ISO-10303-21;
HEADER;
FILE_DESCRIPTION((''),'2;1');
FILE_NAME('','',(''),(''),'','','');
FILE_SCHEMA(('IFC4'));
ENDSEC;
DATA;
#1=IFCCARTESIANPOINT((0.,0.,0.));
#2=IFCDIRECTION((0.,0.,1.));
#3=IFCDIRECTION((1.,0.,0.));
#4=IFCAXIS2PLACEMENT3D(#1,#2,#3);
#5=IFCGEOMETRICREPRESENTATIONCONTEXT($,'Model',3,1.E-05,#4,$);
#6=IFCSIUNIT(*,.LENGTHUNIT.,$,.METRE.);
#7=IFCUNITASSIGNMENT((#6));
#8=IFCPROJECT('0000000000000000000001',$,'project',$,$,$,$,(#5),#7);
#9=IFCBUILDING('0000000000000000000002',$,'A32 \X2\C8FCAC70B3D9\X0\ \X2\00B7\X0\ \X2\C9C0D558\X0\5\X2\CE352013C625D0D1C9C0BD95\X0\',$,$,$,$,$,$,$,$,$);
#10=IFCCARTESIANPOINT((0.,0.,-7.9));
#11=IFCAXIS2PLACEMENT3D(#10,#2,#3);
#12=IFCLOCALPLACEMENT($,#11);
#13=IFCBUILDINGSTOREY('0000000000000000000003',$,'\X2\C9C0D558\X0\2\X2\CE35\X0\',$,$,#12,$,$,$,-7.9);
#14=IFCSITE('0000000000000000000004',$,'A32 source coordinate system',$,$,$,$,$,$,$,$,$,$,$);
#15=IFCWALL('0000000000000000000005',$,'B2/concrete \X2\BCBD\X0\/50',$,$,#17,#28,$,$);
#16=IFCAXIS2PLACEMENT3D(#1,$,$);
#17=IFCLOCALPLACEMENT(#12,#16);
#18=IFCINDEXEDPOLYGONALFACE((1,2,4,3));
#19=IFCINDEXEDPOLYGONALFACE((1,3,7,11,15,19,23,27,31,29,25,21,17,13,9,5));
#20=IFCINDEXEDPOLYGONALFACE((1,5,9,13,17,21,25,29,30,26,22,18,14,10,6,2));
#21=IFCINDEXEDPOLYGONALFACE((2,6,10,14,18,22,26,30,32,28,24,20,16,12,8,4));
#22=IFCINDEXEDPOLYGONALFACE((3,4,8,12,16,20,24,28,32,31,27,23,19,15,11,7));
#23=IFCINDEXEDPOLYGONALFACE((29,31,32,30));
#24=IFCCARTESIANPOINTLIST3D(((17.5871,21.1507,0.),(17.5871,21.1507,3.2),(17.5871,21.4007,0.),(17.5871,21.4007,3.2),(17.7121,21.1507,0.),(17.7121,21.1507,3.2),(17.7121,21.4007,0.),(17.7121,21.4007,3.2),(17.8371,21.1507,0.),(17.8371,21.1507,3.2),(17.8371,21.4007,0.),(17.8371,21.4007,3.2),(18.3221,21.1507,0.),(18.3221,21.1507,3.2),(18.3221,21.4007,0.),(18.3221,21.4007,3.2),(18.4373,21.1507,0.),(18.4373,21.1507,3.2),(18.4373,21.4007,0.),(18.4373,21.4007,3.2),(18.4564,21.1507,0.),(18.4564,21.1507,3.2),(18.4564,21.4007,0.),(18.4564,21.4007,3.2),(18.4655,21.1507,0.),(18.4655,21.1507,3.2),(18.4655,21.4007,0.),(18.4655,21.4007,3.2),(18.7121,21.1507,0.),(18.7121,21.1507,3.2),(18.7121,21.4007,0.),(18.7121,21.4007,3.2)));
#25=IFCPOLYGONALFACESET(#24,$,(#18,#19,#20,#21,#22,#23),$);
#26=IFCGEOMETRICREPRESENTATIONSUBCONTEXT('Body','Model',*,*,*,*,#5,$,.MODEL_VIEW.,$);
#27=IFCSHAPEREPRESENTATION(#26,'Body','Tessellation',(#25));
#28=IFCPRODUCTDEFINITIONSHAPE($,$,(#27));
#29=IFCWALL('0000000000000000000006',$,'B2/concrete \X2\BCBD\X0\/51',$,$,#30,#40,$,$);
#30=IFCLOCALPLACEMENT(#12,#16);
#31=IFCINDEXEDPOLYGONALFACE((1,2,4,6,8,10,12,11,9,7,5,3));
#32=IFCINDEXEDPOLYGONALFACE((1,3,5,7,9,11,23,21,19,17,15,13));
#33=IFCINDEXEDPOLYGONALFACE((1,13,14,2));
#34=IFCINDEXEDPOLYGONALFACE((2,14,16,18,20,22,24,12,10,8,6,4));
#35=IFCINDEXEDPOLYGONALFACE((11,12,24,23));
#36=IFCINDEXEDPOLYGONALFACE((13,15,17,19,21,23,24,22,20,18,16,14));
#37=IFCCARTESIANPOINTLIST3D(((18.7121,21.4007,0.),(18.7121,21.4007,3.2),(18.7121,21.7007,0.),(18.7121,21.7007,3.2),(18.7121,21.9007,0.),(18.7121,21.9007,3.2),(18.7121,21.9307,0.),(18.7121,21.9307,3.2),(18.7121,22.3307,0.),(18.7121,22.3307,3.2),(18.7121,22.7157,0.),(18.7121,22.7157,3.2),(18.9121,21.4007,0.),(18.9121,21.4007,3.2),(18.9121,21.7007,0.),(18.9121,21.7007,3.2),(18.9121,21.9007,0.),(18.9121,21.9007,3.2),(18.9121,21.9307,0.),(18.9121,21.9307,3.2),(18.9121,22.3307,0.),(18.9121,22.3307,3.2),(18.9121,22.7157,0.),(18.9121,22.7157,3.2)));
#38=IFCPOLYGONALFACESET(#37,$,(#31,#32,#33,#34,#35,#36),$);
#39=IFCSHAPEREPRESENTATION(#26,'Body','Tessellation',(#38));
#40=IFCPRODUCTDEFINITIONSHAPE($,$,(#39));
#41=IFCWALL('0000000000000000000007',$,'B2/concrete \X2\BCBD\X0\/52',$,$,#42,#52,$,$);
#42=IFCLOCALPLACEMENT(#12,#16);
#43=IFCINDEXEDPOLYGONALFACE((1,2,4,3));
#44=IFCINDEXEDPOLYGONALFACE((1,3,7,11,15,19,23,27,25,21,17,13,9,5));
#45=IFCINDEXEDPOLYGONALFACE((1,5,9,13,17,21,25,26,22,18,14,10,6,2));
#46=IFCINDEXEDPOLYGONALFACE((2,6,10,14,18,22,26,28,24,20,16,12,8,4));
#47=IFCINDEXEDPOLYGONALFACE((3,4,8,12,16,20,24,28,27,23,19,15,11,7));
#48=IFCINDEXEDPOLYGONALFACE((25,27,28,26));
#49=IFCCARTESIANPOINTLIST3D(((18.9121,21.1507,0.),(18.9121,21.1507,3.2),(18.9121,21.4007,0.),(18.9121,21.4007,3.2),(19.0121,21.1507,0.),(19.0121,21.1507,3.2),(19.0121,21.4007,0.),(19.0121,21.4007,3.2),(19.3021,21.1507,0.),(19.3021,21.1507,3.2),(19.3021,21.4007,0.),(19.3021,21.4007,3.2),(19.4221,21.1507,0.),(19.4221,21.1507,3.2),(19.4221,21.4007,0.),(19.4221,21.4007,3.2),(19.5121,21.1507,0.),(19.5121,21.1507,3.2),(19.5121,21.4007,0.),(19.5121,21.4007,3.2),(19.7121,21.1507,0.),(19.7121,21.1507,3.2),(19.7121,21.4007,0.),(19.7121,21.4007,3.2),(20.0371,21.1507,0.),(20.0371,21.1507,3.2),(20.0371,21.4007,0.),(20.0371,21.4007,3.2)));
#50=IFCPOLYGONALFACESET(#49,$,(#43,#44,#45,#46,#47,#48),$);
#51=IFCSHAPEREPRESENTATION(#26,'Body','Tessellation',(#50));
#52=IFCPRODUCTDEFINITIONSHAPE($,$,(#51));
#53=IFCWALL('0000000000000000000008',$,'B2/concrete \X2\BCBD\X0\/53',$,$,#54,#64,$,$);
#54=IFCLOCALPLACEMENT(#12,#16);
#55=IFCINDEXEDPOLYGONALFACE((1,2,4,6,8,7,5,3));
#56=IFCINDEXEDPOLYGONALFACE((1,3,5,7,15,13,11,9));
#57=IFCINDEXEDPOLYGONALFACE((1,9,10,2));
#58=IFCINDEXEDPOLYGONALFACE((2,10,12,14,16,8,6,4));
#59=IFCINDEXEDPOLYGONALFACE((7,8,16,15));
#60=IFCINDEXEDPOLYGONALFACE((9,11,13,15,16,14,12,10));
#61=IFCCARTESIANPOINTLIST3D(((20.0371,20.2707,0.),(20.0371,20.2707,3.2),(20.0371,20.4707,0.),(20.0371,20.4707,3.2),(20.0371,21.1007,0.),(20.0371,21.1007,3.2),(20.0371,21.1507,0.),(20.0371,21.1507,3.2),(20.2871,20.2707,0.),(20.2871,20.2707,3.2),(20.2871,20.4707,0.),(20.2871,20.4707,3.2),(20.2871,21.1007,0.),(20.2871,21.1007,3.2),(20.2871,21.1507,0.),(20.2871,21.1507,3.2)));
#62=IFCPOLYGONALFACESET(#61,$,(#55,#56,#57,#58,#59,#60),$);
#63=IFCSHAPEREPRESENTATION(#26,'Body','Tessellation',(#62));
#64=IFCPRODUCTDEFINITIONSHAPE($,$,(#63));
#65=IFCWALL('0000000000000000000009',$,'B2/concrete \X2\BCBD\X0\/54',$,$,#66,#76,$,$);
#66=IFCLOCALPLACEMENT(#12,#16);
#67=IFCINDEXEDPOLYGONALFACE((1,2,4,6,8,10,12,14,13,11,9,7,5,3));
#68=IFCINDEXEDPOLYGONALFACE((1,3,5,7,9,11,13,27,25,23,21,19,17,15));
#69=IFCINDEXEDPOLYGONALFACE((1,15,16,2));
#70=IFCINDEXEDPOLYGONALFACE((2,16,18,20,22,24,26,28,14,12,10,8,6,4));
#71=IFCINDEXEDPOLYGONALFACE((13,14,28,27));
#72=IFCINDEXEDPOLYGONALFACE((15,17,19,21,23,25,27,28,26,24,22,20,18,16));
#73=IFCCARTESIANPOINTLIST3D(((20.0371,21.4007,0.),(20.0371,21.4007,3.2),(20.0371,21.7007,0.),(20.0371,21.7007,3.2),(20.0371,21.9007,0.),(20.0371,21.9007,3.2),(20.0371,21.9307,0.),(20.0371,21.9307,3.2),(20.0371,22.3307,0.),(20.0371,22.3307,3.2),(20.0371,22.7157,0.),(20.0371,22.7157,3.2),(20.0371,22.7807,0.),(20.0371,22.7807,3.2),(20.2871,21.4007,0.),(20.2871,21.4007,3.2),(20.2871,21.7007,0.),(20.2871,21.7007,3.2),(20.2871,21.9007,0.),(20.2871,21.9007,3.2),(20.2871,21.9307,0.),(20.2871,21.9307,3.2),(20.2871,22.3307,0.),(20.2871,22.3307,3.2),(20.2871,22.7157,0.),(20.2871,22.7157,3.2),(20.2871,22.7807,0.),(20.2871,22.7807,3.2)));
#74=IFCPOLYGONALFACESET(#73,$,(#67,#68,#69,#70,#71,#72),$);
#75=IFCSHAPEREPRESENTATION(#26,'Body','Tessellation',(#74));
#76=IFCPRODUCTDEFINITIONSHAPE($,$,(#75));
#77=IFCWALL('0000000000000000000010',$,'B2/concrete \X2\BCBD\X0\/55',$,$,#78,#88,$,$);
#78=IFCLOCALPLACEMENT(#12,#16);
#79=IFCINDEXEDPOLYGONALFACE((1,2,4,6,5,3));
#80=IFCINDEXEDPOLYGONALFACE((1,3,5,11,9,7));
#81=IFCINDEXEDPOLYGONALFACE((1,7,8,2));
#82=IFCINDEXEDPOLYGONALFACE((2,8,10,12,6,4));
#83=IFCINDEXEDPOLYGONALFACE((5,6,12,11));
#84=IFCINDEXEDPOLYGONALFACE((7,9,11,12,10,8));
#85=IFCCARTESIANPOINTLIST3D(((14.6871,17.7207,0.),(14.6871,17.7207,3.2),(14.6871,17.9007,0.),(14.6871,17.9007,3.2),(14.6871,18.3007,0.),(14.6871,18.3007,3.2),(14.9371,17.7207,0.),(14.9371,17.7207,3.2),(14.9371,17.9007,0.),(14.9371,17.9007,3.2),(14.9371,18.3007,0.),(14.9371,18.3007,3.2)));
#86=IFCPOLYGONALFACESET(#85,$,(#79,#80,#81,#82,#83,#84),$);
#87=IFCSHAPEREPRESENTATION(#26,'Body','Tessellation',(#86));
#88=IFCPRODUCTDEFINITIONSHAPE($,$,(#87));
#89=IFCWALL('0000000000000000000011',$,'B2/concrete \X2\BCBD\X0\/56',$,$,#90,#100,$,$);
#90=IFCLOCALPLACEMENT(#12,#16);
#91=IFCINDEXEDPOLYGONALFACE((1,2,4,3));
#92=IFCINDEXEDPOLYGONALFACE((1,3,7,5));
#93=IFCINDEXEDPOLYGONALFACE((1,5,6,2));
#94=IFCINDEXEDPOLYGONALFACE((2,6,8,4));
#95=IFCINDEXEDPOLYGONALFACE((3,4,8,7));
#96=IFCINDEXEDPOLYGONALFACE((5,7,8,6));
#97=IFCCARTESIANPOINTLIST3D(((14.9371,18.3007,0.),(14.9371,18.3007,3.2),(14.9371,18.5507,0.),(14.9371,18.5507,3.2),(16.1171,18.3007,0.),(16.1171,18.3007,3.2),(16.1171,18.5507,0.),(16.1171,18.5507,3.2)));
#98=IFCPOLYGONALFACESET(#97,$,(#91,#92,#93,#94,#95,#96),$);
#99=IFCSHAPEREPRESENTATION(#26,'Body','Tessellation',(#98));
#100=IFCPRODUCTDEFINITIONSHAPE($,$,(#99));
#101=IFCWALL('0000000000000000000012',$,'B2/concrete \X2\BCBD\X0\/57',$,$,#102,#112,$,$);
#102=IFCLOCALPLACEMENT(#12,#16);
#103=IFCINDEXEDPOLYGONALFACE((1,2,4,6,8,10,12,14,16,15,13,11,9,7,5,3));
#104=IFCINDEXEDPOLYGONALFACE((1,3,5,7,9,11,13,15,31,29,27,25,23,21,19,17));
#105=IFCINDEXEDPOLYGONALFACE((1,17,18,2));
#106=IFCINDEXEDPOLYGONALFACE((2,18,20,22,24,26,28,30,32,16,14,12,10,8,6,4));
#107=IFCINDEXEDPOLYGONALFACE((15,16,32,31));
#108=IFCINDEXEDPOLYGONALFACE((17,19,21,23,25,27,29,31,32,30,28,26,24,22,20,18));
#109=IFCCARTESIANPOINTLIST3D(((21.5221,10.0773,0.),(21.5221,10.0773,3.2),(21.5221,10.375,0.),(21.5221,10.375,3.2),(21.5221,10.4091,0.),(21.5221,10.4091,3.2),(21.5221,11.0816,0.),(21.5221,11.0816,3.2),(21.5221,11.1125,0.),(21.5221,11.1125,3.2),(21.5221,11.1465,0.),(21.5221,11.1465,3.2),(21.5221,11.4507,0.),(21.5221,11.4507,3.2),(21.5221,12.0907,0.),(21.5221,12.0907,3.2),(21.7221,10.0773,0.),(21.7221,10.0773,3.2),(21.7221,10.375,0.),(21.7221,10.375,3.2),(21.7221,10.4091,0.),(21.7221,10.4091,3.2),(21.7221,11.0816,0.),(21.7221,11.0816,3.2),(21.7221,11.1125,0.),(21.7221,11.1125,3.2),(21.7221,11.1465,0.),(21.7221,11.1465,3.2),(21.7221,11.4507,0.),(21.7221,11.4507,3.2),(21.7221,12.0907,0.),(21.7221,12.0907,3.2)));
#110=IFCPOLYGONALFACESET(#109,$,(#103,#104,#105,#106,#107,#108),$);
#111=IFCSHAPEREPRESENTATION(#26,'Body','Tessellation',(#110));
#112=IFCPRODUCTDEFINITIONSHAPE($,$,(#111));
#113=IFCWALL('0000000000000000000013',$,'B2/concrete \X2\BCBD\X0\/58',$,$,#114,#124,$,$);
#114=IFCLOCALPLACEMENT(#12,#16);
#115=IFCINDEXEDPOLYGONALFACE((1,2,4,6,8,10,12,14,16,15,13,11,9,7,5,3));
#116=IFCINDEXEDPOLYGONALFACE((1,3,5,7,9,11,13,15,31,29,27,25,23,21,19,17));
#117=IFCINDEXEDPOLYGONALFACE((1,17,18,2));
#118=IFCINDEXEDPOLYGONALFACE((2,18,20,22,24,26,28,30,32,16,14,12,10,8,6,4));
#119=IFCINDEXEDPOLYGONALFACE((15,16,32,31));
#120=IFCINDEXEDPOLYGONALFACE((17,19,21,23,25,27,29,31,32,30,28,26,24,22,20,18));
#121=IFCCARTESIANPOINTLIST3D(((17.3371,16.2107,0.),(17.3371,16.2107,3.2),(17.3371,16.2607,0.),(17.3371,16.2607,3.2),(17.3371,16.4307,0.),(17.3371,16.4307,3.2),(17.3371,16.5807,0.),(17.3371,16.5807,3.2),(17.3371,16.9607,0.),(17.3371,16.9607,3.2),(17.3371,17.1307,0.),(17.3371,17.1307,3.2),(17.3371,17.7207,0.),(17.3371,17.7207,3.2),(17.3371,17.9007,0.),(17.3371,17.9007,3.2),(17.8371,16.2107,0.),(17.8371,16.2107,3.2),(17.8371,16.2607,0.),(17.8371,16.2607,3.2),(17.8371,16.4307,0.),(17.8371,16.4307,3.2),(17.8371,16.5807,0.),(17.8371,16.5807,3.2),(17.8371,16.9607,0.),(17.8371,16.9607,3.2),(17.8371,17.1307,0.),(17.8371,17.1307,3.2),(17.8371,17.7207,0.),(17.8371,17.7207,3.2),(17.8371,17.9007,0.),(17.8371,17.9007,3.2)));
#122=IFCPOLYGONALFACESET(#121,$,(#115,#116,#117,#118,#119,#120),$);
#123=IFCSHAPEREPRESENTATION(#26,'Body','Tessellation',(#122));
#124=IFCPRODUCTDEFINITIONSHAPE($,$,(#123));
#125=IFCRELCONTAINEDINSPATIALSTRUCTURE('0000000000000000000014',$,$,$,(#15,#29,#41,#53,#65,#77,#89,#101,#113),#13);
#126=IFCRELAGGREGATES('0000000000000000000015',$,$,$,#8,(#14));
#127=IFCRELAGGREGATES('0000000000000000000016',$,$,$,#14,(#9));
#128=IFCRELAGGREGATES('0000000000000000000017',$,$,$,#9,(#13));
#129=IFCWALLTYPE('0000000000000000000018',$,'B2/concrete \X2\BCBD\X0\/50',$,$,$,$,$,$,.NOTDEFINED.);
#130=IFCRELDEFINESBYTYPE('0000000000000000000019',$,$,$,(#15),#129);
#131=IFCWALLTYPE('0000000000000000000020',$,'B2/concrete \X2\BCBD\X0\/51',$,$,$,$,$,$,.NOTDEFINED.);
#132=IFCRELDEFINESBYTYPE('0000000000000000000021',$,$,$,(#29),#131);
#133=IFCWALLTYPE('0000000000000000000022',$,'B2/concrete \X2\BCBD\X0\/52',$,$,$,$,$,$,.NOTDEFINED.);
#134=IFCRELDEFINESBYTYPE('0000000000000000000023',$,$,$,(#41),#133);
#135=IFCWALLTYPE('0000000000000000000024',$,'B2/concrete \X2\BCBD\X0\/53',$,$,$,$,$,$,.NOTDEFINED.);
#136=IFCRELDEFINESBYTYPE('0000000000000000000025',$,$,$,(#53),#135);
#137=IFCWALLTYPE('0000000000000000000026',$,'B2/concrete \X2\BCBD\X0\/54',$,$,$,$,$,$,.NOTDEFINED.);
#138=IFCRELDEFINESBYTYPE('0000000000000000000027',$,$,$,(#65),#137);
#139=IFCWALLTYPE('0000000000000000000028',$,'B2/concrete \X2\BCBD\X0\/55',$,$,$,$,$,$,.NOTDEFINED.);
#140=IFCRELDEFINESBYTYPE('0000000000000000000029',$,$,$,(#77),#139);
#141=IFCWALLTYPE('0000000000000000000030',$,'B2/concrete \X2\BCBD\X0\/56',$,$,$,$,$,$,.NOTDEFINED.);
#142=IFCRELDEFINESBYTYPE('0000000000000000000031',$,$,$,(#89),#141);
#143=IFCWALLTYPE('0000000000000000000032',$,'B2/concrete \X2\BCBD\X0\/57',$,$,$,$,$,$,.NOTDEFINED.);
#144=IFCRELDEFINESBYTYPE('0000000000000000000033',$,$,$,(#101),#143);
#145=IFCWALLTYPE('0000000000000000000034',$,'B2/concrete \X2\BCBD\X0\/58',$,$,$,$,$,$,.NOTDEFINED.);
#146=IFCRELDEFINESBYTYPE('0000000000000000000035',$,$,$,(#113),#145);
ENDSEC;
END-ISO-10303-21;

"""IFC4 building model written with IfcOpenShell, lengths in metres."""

from ifc_helpers import new_model, si_unit, frame, origin, origin_with_axes, place, context, subcontext, project, spatial, polyline, outline, extrude, source, transform, mapped, type_object, type_shapes, element, save


model = new_model("IFC4")

# Units and contexts
model_context = context("Model", 3, precision=1e-05, world=origin_with_axes())
body_context = subcontext(model_context, "Body", "Model", "MODEL_VIEW")
ifc_project = project(units=[si_unit("LENGTHUNIT", "METRE")], contexts=[model_context])

# Site, building, storey
site = spatial("IfcSite", under=ifc_project, Name="A32 source coordinate system")
building = spatial("IfcBuilding", under=site, Name="A32 주거동 · 지하5층–옥탑지붕")
storey_placement = place(None, frame((0.0, 0.0, -7.9), z_axis=(0.0, 0.0, 1.0), x_axis=(1.0, 0.0, 0.0)))
storey = spatial("IfcBuildingStorey", under=building, at=storey_placement, Name="지하2층", Elevation=-7.9)

# Walls
wall_type_1 = type_object("IfcWallType", Name="B2/concrete 벽/50", PredefinedType="NOTDEFINED")
shared_shape_1 = source(origin(), body_context, "Body", "SweptSolid", [
    extrude(outline(polyline([(17.8371, 21.4007), (18.3221, 21.4007), (18.4373, 21.4007), (18.4564, 21.4007), (18.4655, 21.4007), (18.7121, 21.4007), (18.7121, 21.1507), (18.4655, 21.1507), (18.4564, 21.1507), (18.4373, 21.1507), (18.3221, 21.1507), (17.8371, 21.1507), (17.7121, 21.1507), (17.5871, 21.1507), (17.5871, 21.4007), (17.7121, 21.4007), (17.8371, 21.4007)])), origin(), (0.0, 0.0, 1.0), 3.2),
])
type_shapes(wall_type_1, [shared_shape_1])
wall_1_placement = place(storey_placement, origin_with_axes())
element("IfcWall", 1, at=wall_1_placement, inside=storey, type_object=wall_type_1, Name="B2/concrete 벽/50", context=body_context, shape_type="MappedRepresentation", body=[
    mapped(shared_shape_1, transform((0.0, 0.0, 0.0), scale=1.0)),
])
wall_type_2 = type_object("IfcWallType", Name="B2/concrete 벽/51", PredefinedType="NOTDEFINED")
shared_shape_2 = source(origin(), body_context, "Body", "SweptSolid", [
    extrude(outline(polyline([(18.7121, 21.9307), (18.7121, 22.3307), (18.7121, 22.7157), (18.9121, 22.7157), (18.9121, 22.3307), (18.9121, 21.9307), (18.9121, 21.9007), (18.9121, 21.7007), (18.9121, 21.4007), (18.7121, 21.4007), (18.7121, 21.7007), (18.7121, 21.9007), (18.7121, 21.9307)])), origin(), (0.0, 0.0, 1.0), 3.2),
])
type_shapes(wall_type_2, [shared_shape_2])
wall_2_placement = place(storey_placement, origin_with_axes())
element("IfcWall", 2, at=wall_2_placement, inside=storey, type_object=wall_type_2, Name="B2/concrete 벽/51", context=body_context, shape_type="MappedRepresentation", body=[
    mapped(shared_shape_2, transform((0.0, 0.0, 0.0), scale=1.0)),
])
wall_type_3 = type_object("IfcWallType", Name="B2/concrete 벽/52", PredefinedType="NOTDEFINED")
shared_shape_3 = source(origin(), body_context, "Body", "SweptSolid", [
    extrude(outline(polyline([(19.4221, 21.4007), (19.5121, 21.4007), (19.7121, 21.4007), (20.0371, 21.4007), (20.0371, 21.1507), (19.7121, 21.1507), (19.5121, 21.1507), (19.4221, 21.1507), (19.3021, 21.1507), (19.0121, 21.1507), (18.9121, 21.1507), (18.9121, 21.4007), (19.0121, 21.4007), (19.3021, 21.4007), (19.4221, 21.4007)])), origin(), (0.0, 0.0, 1.0), 3.2),
])
type_shapes(wall_type_3, [shared_shape_3])
wall_3_placement = place(storey_placement, origin_with_axes())
element("IfcWall", 3, at=wall_3_placement, inside=storey, type_object=wall_type_3, Name="B2/concrete 벽/52", context=body_context, shape_type="MappedRepresentation", body=[
    mapped(shared_shape_3, transform((0.0, 0.0, 0.0), scale=1.0)),
])
wall_type_4 = type_object("IfcWallType", Name="B2/concrete 벽/53", PredefinedType="NOTDEFINED")
shared_shape_4 = source(origin(), body_context, "Body", "SweptSolid", [
    extrude(outline(polyline([(20.2871, 20.4707), (20.2871, 20.2707), (20.0371, 20.2707), (20.0371, 20.4707), (20.0371, 21.1007), (20.0371, 21.1507), (20.2871, 21.1507), (20.2871, 21.1007), (20.2871, 20.4707)])), origin(), (0.0, 0.0, 1.0), 3.2),
])
type_shapes(wall_type_4, [shared_shape_4])
wall_4_placement = place(storey_placement, origin_with_axes())
element("IfcWall", 4, at=wall_4_placement, inside=storey, type_object=wall_type_4, Name="B2/concrete 벽/53", context=body_context, shape_type="MappedRepresentation", body=[
    mapped(shared_shape_4, transform((0.0, 0.0, 0.0), scale=1.0)),
])
wall_type_5 = type_object("IfcWallType", Name="B2/concrete 벽/54", PredefinedType="NOTDEFINED")
shared_shape_5 = source(origin(), body_context, "Body", "SweptSolid", [
    extrude(outline(polyline([(20.0371, 21.9307), (20.0371, 22.3307), (20.0371, 22.7157), (20.0371, 22.7807), (20.2871, 22.7807), (20.2871, 22.7157), (20.2871, 22.3307), (20.2871, 21.9307), (20.2871, 21.9007), (20.2871, 21.7007), (20.2871, 21.4007), (20.0371, 21.4007), (20.0371, 21.7007), (20.0371, 21.9007), (20.0371, 21.9307)])), origin(), (0.0, 0.0, 1.0), 3.2),
])
type_shapes(wall_type_5, [shared_shape_5])
wall_5_placement = place(storey_placement, origin_with_axes())
element("IfcWall", 5, at=wall_5_placement, inside=storey, type_object=wall_type_5, Name="B2/concrete 벽/54", context=body_context, shape_type="MappedRepresentation", body=[
    mapped(shared_shape_5, transform((0.0, 0.0, 0.0), scale=1.0)),
])
wall_type_6 = type_object("IfcWallType", Name="B2/concrete 벽/55", PredefinedType="NOTDEFINED")
shared_shape_6 = source(origin(), body_context, "Body", "SweptSolid", [
    extrude(outline(polyline([(14.9371, 17.7207), (14.6871, 17.7207), (14.6871, 17.9007), (14.6871, 18.3007), (14.9371, 18.3007), (14.9371, 17.9007), (14.9371, 17.7207)])), origin(), (0.0, 0.0, 1.0), 3.2),
])
type_shapes(wall_type_6, [shared_shape_6])
wall_6_placement = place(storey_placement, origin_with_axes())
element("IfcWall", 6, at=wall_6_placement, inside=storey, type_object=wall_type_6, Name="B2/concrete 벽/55", context=body_context, shape_type="MappedRepresentation", body=[
    mapped(shared_shape_6, transform((0.0, 0.0, 0.0), scale=1.0)),
])
wall_type_7 = type_object("IfcWallType", Name="B2/concrete 벽/56", PredefinedType="NOTDEFINED")
shared_shape_7 = source(origin(), body_context, "Body", "SweptSolid", [
    extrude(outline(polyline([(16.1171, 18.3007), (14.9371, 18.3007), (14.9371, 18.5507), (16.1171, 18.5507), (16.1171, 18.3007)])), origin(), (0.0, 0.0, 1.0), 3.2),
])
type_shapes(wall_type_7, [shared_shape_7])
wall_7_placement = place(storey_placement, origin_with_axes())
element("IfcWall", 7, at=wall_7_placement, inside=storey, type_object=wall_type_7, Name="B2/concrete 벽/56", context=body_context, shape_type="MappedRepresentation", body=[
    mapped(shared_shape_7, transform((0.0, 0.0, 0.0), scale=1.0)),
])
wall_type_8 = type_object("IfcWallType", Name="B2/concrete 벽/57", PredefinedType="NOTDEFINED")
shared_shape_8 = source(origin(), body_context, "Body", "SweptSolid", [
    extrude(outline(polyline([(21.7221, 12.0907), (21.7221, 11.4507), (21.7221, 11.1465), (21.7221, 11.1125), (21.7221, 11.0816), (21.7221, 10.4091), (21.7221, 10.375), (21.7221, 10.0773), (21.5221, 10.0773), (21.5221, 10.375), (21.5221, 10.4091), (21.5221, 11.0816), (21.5221, 11.1125), (21.5221, 11.1465), (21.5221, 11.4507), (21.5221, 12.0907), (21.7221, 12.0907)])), origin(), (0.0, 0.0, 1.0), 3.2),
])
type_shapes(wall_type_8, [shared_shape_8])
wall_8_placement = place(storey_placement, origin_with_axes())
element("IfcWall", 8, at=wall_8_placement, inside=storey, type_object=wall_type_8, Name="B2/concrete 벽/57", context=body_context, shape_type="MappedRepresentation", body=[
    mapped(shared_shape_8, transform((0.0, 0.0, 0.0), scale=1.0)),
])
wall_type_9 = type_object("IfcWallType", Name="B2/concrete 벽/58", PredefinedType="NOTDEFINED")
shared_shape_9 = source(origin(), body_context, "Body", "SweptSolid", [
    extrude(outline(polyline([(17.8371, 17.1307), (17.8371, 16.9607), (17.8371, 16.5807), (17.8371, 16.4307), (17.8371, 16.2607), (17.8371, 16.2107), (17.3371, 16.2107), (17.3371, 16.2607), (17.3371, 16.4307), (17.3371, 16.5807), (17.3371, 16.9607), (17.3371, 17.1307), (17.3371, 17.7207), (17.3371, 17.9007), (17.8371, 17.9007), (17.8371, 17.7207), (17.8371, 17.1307)])), origin(), (0.0, 0.0, 1.0), 3.2),
])
type_shapes(wall_type_9, [shared_shape_9])
wall_9_placement = place(storey_placement, origin_with_axes())
element("IfcWall", 9, at=wall_9_placement, inside=storey, type_object=wall_type_9, Name="B2/concrete 벽/58", context=body_context, shape_type="MappedRepresentation", body=[
    mapped(shared_shape_9, transform((0.0, 0.0, 0.0), scale=1.0)),
])

save(model, "model.ifc")
